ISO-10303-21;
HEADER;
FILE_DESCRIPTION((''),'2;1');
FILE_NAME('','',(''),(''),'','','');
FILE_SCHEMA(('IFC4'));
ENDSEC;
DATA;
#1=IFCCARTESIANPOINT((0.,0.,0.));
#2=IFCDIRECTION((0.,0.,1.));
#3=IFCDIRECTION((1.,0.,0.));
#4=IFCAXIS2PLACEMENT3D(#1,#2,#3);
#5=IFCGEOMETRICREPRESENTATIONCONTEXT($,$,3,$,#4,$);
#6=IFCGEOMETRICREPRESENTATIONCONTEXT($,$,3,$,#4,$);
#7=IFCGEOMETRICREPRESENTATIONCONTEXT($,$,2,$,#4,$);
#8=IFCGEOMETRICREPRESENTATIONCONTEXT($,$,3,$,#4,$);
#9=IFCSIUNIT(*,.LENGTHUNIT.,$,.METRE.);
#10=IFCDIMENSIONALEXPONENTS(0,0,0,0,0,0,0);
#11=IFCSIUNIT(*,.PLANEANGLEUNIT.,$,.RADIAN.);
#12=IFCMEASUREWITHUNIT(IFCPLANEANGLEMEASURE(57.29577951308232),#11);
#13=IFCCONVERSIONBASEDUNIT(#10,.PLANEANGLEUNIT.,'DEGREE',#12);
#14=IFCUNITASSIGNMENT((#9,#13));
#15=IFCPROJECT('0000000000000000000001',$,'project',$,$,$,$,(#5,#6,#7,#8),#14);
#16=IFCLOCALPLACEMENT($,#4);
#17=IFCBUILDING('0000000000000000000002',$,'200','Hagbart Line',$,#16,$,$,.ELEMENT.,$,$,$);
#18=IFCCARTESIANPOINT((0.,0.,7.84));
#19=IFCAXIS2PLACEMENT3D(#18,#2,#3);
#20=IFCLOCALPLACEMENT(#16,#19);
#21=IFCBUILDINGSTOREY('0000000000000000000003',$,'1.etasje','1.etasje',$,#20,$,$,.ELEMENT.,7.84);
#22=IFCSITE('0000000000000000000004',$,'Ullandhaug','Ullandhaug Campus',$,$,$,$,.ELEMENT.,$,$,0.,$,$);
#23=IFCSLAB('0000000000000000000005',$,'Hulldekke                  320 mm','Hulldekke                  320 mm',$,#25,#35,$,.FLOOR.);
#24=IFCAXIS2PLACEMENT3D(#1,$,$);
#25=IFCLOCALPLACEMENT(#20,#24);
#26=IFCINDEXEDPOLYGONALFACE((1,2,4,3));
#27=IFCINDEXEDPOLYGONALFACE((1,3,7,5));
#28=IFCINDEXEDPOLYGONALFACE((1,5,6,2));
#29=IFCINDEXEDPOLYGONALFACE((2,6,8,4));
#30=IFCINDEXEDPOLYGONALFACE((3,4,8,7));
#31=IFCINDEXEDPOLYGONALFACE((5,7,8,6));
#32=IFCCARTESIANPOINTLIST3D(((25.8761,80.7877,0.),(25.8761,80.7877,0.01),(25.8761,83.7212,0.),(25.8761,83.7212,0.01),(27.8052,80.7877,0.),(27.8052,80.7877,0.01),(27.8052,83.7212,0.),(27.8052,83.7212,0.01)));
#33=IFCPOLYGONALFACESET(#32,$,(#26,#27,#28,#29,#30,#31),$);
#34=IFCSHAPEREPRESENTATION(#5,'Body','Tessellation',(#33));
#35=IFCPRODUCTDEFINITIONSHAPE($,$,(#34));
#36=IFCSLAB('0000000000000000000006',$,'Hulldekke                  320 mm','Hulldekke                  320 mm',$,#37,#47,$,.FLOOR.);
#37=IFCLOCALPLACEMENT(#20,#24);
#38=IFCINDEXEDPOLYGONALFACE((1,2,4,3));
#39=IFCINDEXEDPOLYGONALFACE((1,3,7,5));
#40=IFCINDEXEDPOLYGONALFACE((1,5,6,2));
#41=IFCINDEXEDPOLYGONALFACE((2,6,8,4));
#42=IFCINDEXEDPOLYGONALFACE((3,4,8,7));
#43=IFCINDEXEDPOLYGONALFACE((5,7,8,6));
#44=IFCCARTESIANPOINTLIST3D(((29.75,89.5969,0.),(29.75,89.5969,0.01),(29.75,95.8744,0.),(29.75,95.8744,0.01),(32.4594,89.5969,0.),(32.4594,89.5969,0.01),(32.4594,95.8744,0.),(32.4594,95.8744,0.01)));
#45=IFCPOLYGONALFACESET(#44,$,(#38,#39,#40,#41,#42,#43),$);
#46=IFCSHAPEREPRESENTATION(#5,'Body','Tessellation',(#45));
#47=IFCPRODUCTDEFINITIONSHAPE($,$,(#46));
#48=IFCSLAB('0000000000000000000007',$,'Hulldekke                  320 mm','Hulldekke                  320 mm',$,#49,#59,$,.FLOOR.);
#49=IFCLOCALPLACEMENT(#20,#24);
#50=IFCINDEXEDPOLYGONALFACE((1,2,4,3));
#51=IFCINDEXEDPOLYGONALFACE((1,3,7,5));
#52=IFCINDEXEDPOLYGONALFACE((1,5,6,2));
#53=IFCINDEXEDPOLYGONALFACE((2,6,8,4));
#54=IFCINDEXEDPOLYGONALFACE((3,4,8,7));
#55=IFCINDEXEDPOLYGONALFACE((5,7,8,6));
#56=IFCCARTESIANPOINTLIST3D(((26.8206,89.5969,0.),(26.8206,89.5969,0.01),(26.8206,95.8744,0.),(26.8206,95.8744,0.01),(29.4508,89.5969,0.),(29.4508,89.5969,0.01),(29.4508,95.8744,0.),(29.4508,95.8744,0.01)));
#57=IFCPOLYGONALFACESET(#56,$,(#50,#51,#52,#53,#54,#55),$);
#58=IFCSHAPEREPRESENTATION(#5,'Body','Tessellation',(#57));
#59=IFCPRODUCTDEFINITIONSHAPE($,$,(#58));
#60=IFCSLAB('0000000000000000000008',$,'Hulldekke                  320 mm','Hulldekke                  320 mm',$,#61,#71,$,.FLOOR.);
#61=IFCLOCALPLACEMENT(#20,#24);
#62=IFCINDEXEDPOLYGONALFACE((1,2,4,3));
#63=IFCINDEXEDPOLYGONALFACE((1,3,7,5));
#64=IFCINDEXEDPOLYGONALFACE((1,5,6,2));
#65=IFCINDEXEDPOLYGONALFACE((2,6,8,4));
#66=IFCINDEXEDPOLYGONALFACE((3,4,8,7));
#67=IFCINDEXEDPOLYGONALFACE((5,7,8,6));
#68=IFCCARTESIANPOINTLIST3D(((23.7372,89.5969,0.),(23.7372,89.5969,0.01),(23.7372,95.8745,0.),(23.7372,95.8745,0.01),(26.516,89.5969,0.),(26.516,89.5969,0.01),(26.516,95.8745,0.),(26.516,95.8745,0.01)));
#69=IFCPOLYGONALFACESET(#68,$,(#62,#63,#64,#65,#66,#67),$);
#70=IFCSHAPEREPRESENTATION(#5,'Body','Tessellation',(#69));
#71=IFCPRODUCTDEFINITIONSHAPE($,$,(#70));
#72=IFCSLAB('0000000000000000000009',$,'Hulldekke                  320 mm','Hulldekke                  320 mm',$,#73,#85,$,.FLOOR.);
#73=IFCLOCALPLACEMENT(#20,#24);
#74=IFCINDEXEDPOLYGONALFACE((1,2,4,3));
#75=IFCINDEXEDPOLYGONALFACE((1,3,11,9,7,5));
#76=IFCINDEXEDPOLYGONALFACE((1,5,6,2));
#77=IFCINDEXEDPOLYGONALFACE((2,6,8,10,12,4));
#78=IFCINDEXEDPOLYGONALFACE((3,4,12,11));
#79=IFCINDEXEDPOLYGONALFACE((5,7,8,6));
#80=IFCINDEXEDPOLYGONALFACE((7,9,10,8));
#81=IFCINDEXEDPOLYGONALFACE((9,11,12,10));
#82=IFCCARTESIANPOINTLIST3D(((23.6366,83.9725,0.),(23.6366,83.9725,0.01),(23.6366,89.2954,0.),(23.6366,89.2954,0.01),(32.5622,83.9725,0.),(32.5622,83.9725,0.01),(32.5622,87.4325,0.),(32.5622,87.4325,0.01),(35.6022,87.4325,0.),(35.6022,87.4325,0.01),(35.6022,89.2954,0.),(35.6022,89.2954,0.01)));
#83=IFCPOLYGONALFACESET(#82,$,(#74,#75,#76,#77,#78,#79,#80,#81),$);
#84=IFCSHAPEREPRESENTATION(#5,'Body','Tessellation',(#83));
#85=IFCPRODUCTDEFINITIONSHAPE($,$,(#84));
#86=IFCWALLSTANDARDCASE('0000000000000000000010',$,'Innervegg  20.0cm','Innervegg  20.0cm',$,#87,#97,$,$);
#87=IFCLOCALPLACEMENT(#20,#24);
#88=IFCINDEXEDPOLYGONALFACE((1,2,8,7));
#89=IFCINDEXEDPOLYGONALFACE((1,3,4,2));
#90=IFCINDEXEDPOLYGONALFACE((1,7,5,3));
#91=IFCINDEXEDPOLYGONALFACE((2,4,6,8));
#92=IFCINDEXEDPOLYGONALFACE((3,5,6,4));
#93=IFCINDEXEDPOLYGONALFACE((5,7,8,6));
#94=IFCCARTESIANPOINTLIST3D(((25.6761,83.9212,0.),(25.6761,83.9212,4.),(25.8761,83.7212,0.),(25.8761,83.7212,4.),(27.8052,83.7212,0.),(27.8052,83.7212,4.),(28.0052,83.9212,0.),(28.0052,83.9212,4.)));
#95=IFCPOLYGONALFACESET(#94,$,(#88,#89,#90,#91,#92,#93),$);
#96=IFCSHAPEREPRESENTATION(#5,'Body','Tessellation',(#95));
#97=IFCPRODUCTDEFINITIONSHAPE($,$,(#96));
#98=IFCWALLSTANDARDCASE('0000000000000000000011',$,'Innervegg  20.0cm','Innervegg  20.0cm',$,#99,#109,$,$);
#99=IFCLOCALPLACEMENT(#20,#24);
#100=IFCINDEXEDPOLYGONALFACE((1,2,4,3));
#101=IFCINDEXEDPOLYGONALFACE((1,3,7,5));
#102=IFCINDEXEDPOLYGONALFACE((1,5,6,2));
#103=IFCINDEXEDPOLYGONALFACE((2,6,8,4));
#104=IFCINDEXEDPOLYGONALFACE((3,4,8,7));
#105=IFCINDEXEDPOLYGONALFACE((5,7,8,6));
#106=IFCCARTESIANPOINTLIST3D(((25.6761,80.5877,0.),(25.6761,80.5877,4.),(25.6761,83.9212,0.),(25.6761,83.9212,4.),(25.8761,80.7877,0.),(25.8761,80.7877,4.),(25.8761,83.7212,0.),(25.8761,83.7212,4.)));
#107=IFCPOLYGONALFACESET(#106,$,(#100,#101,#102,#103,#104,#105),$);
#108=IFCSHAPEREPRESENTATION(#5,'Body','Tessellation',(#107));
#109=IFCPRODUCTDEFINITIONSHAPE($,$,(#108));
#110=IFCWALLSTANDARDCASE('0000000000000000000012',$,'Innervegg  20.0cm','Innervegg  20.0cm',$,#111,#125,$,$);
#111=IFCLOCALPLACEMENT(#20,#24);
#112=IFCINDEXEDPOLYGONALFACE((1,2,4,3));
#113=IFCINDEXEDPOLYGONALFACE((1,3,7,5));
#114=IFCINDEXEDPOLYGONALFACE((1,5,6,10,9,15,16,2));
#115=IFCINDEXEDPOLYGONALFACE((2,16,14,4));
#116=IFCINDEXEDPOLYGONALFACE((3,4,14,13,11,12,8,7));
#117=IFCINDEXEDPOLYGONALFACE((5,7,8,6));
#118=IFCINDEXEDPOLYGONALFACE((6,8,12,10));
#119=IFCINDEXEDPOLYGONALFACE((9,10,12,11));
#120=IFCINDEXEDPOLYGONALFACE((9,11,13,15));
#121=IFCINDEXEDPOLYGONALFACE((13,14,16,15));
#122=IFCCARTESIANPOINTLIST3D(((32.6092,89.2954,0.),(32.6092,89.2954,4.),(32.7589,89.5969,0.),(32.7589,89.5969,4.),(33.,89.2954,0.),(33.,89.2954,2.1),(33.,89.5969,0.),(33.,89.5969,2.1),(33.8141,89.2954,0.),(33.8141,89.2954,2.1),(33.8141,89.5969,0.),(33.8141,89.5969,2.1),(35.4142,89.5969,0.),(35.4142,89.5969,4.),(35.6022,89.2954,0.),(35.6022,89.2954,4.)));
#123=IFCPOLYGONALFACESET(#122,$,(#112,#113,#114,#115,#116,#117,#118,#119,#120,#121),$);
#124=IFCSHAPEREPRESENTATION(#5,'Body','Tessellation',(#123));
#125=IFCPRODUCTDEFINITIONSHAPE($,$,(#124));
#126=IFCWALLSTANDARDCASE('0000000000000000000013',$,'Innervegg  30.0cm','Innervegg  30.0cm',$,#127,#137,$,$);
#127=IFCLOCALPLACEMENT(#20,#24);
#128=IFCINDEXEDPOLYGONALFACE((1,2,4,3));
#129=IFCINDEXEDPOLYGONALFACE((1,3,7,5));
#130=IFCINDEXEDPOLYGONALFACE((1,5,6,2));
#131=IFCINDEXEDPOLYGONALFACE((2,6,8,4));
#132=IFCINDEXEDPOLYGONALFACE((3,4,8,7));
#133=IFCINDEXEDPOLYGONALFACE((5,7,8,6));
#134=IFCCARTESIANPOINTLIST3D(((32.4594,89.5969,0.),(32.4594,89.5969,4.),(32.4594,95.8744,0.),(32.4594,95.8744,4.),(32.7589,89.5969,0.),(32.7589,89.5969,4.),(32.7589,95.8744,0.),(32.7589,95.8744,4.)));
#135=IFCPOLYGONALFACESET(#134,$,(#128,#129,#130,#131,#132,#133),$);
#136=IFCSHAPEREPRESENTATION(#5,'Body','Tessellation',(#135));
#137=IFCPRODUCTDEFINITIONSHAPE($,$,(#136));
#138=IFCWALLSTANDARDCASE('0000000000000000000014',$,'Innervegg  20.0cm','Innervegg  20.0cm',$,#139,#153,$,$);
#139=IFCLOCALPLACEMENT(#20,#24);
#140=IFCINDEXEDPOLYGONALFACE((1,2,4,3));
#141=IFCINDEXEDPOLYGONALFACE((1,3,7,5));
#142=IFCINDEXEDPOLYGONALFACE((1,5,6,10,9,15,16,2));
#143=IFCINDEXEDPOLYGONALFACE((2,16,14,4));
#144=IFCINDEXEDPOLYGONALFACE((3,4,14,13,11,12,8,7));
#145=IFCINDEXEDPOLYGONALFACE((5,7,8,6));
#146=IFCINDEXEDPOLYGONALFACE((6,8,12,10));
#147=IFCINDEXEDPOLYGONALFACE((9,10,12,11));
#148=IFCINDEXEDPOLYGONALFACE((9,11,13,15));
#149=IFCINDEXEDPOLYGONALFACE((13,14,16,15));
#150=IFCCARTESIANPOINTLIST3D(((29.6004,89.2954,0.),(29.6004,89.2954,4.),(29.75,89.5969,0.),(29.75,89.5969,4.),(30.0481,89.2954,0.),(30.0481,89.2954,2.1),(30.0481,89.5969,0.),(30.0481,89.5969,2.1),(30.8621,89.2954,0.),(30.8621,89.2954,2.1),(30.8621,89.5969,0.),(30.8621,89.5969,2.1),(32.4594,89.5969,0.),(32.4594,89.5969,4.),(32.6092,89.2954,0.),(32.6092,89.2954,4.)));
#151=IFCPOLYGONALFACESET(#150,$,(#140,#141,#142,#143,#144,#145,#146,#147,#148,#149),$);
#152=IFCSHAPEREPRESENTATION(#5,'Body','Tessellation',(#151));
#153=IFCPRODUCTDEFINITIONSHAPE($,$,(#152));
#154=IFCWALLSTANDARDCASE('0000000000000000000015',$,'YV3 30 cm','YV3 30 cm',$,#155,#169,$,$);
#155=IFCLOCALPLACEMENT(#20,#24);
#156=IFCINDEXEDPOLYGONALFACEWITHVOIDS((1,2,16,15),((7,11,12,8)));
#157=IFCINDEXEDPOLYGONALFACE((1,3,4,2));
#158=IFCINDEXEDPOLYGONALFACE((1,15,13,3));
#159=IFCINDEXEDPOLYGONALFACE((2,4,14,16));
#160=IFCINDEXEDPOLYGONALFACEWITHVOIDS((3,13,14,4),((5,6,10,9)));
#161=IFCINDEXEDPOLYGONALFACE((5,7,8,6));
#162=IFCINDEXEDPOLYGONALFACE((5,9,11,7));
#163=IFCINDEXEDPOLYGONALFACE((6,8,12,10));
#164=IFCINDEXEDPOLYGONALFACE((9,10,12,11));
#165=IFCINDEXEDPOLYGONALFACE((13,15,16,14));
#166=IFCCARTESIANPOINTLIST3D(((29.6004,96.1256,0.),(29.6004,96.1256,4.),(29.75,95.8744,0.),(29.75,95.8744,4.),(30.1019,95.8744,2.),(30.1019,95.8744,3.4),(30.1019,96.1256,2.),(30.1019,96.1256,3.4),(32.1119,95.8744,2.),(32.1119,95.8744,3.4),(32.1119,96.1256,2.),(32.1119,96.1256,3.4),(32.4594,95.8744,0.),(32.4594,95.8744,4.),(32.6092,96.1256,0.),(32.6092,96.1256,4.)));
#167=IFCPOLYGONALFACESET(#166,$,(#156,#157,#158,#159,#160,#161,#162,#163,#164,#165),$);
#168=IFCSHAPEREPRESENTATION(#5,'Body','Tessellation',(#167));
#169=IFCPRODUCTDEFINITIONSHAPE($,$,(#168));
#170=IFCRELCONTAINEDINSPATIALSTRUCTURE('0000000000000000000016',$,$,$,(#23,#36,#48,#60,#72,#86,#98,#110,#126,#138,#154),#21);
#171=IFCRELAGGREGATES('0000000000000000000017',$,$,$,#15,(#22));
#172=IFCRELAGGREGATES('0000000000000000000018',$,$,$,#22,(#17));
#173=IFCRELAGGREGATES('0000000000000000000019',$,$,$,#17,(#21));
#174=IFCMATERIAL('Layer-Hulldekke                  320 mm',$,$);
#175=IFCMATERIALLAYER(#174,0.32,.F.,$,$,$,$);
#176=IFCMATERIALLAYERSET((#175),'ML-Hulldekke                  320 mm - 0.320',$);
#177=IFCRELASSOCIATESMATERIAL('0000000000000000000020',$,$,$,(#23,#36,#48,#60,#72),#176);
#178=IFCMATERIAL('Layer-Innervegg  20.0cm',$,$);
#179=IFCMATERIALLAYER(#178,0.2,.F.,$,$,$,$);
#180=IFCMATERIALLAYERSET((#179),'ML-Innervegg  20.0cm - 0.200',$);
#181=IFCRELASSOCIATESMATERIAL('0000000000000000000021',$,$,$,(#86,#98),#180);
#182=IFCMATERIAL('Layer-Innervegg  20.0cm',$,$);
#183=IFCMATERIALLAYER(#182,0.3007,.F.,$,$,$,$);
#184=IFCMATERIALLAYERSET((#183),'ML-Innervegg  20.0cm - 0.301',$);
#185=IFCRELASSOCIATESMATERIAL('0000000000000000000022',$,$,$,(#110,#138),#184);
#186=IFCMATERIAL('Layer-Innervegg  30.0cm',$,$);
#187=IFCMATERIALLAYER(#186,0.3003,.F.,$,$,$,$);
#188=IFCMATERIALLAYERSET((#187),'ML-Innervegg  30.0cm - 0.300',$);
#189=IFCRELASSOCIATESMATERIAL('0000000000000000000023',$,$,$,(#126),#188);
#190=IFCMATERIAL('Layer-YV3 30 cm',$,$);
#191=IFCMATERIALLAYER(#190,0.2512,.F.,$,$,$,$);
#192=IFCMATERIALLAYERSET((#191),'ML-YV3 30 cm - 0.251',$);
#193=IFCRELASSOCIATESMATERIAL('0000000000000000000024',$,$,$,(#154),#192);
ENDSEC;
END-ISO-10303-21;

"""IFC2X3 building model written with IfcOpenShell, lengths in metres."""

from ifc_helpers import new_model, entity, si_unit, converted_unit, frame, origin_with_axes, place, context, project, spatial, polyline, outline, extrude, material, layer, layer_set, layer_usage, element, save


model = new_model("IFC2X3")

# Units and contexts
context_of_model_1 = context(None, 3, world=origin_with_axes())
context_of_model_2 = context(None, 3, world=origin_with_axes())
context_of_model_3 = context(None, 2, world=origin_with_axes())
context_of_model_4 = context(None, 3, world=origin_with_axes())
ifc_project = project(units=[si_unit("LENGTHUNIT", "METRE"), converted_unit("PLANEANGLEUNIT", "DEGREE", entity("IfcPlaneAngleMeasure", 57.29577951308232), si_unit("PLANEANGLEUNIT", "RADIAN"), dimensions=[0, 0, 0, 0, 0, 0, 0])], contexts=[context_of_model_1, context_of_model_2, context_of_model_3, context_of_model_4])

# Site, building, storey
site = spatial("IfcSite", under=ifc_project, Name="Ullandhaug", Description="Ullandhaug Campus", CompositionType="ELEMENT", RefElevation=0.0)
building_placement = place(None, origin_with_axes())
building = spatial("IfcBuilding", under=site, at=building_placement, Name="200", Description="Hagbart Line", CompositionType="ELEMENT")
storey_placement = place(building_placement, frame((0.0, 0.0, 7.84), z_axis=(0.0, 0.0, 1.0), x_axis=(1.0, 0.0, 0.0)))
storey = spatial("IfcBuildingStorey", under=building, at=storey_placement, Name="1.etasje", Description="1.etasje", CompositionType="ELEMENT", Elevation=7.84)

# Slabs
ifc_material_1 = material(Name="Layer-Hulldekke                  320 mm")
ifc_layer_1 = layer(ifc_material_1, 0.32, ventilated=False)
ifc_layer_set_1 = layer_set([ifc_layer_1], Name="ML-Hulldekke                  320 mm - 0.320")
ifc_layer_usage_1 = layer_usage(ifc_layer_set_1, "AXIS2", "POSITIVE", 0.0)
slab_1_placement = place(storey_placement, frame((25.8761, 80.7877, 0.0), z_axis=(0.0, 0.0, 1.0), x_axis=(1.0, 0.0, 0.0)))
element("IfcSlab", 1, at=slab_1_placement, inside=storey, material=ifc_layer_usage_1, Name="Hulldekke                  320 mm", Description="Hulldekke                  320 mm", PredefinedType="FLOOR", context=context_of_model_1, shape_type="SweptSolid", body=[
    extrude(outline(polyline([(0.0, 0.0), (1.929, 0.0), (1.929, 2.9335), (0.0, 2.9335), (0.0, 0.0)])), origin_with_axes(), (0.0, 0.0, 1.0), 0.01),
])
slab_2_placement = place(storey_placement, frame((29.75, 89.5969, 0.0), z_axis=(0.0, 0.0, 1.0), x_axis=(1.0, 0.0, 0.0)))
element("IfcSlab", 2, at=slab_2_placement, inside=storey, material=ifc_layer_usage_1, Name="Hulldekke                  320 mm", Description="Hulldekke                  320 mm", PredefinedType="FLOOR", context=context_of_model_1, shape_type="SweptSolid", body=[
    extrude(outline(polyline([(0.0, 0.0), (2.7094, 0.0), (2.7094, 6.2775), (0.0, 6.2775), (0.0, 0.0)])), origin_with_axes(), (0.0, 0.0, 1.0), 0.01),
])
slab_3_placement = place(storey_placement, frame((26.8206, 89.5969, 0.0), z_axis=(0.0, 0.0, 1.0), x_axis=(1.0, 0.0, 0.0)))
element("IfcSlab", 3, at=slab_3_placement, inside=storey, material=ifc_layer_usage_1, Name="Hulldekke                  320 mm", Description="Hulldekke                  320 mm", PredefinedType="FLOOR", context=context_of_model_1, shape_type="SweptSolid", body=[
    extrude(outline(polyline([(0.0, 0.0), (2.6303, 0.0), (2.6303, 6.2775), (0.0, 6.2775), (0.0, 0.0)])), origin_with_axes(), (0.0, 0.0, 1.0), 0.01),
])
slab_4_placement = place(storey_placement, frame((23.7372, 89.5969, 0.0), z_axis=(0.0, 0.0, 1.0), x_axis=(1.0, 0.0, 0.0)))
element("IfcSlab", 4, at=slab_4_placement, inside=storey, material=ifc_layer_usage_1, Name="Hulldekke                  320 mm", Description="Hulldekke                  320 mm", PredefinedType="FLOOR", context=context_of_model_1, shape_type="SweptSolid", body=[
    extrude(outline(polyline([(0.0, 0.0), (2.7788, 0.0), (2.7788, 6.2775), (0.0, 6.2775), (0.0, 0.0)])), origin_with_axes(), (0.0, 0.0, 1.0), 0.01),
])
slab_5_placement = place(storey_placement, frame((23.6366, 83.9725, 0.0), z_axis=(0.0, 0.0, 1.0), x_axis=(1.0, 0.0, 0.0)))
element("IfcSlab", 5, at=slab_5_placement, inside=storey, material=ifc_layer_usage_1, Name="Hulldekke                  320 mm", Description="Hulldekke                  320 mm", PredefinedType="FLOOR", context=context_of_model_1, shape_type="SweptSolid", body=[
    extrude(outline(polyline([(0.0, 0.0), (8.9255, 0.0), (8.9255, 3.46), (11.9655, 3.46), (11.9655, 5.323), (0.0, 5.323), (0.0, 0.0)])), origin_with_axes(), (0.0, 0.0, 1.0), 0.01),
])

# Walls
ifc_material_2 = material(Name="Layer-Innervegg  20.0cm")
ifc_layer_2 = layer(ifc_material_2, 0.2, ventilated=False)
ifc_layer_set_2 = layer_set([ifc_layer_2], Name="ML-Innervegg  20.0cm - 0.200")
ifc_layer_usage_2 = layer_usage(ifc_layer_set_2, "AXIS2", "POSITIVE", 0.0)
wall_1_placement = place(storey_placement, frame((28.0052, 83.9212, 0.0), z_axis=(0.0, 0.0, 1.0), x_axis=(-1.0, 0.0, 0.0)))
element("IfcWallStandardCase", 6, at=wall_1_placement, inside=storey, material=ifc_layer_usage_2, Name="Innervegg  20.0cm", Description="Innervegg  20.0cm", context=context_of_model_1, shape_type="SweptSolid", body=[
    extrude(outline(polyline([(0.0, 0.0), (2.329, 0.0), (2.129, 0.2), (0.2, 0.2), (0.0, 0.0)])), frame((0.0, 0.0, 0.0), z_axis=(0.0, 0.0, 1.0), x_axis=(1.0, 0.0, 0.0)), (0.0, 0.0, 1.0), 4.0),
])
wall_2_placement = place(storey_placement, frame((25.6761, 83.9212, 0.0), z_axis=(0.0, 0.0, 1.0), x_axis=(0.0, -1.0, 0.0)))
element("IfcWallStandardCase", 7, at=wall_2_placement, inside=storey, material=ifc_layer_usage_2, Name="Innervegg  20.0cm", Description="Innervegg  20.0cm", context=context_of_model_1, shape_type="SweptSolid", body=[
    extrude(outline(polyline([(0.0, 0.0), (3.3335, 0.0), (3.1335, 0.2), (0.2, 0.2), (0.0, 0.0)])), frame((0.0, 0.0, 0.0), z_axis=(0.0, 0.0, 1.0), x_axis=(1.0, 0.0, 0.0)), (0.0, 0.0, 1.0), 4.0),
])

# Wall, opening
ifc_material_3 = material(Name="Layer-Innervegg  20.0cm")
ifc_layer_3 = layer(ifc_material_3, 0.3007, ventilated=False)
ifc_layer_set_3 = layer_set([ifc_layer_3], Name="ML-Innervegg  20.0cm - 0.301")
ifc_layer_usage_3 = layer_usage(ifc_layer_set_3, "AXIS2", "POSITIVE", 0.0)
wall_3_placement = place(storey_placement, frame((32.6092, 89.2954, 0.0), z_axis=(0.0, 0.0, 1.0), x_axis=(1.0, 0.0, 0.0)))
wall_3 = element("IfcWallStandardCase", 8, at=wall_3_placement, inside=storey, material=ifc_layer_usage_3, Name="Innervegg  20.0cm", Description="Innervegg  20.0cm", context=context_of_model_1, shape_type="SweptSolid", body=[
    extrude(outline(polyline([(0.0, 0.0), (2.993, 0.0), (2.805, 0.3015), (0.1498, 0.3015), (0.0, 0.0)])), origin_with_axes(), (0.0, 0.0, 1.0), 4.0),
])
opening_1_placement = place(wall_3_placement, frame((0.3909, 0.3015, 0.0), z_axis=(0.0, 0.0, 1.0), x_axis=(1.0, 0.0, 0.0)))
element("IfcOpeningElement", 9, at=opening_1_placement, cuts=wall_3, context=context_of_model_1, shape_type="SweptSolid", body=[
    extrude(outline(polyline([(0.0, 0.0), (2.1, 0.0), (2.1, 0.8141), (0.0, 0.8141), (0.0, 0.0)])), frame((0.0, 0.0, 0.0), z_axis=(0.0, 1.0, 0.0), x_axis=(0.0, 0.0, 1.0)), (0.0, 0.0, -1.0), 0.3015),
])

# Wall
ifc_material_4 = material(Name="Layer-Innervegg  30.0cm")
ifc_layer_4 = layer(ifc_material_4, 0.3003, ventilated=False)
ifc_layer_set_4 = layer_set([ifc_layer_4], Name="ML-Innervegg  30.0cm - 0.300")
ifc_layer_usage_4 = layer_usage(ifc_layer_set_4, "AXIS2", "POSITIVE", 0.0)
wall_4_placement = place(storey_placement, frame((32.4594, 95.8744, 0.0), z_axis=(0.0, 0.0, 1.0), x_axis=(0.0, -1.0, 0.0)))
element("IfcWallStandardCase", 10, at=wall_4_placement, inside=storey, material=ifc_layer_usage_4, Name="Innervegg  30.0cm", Description="Innervegg  30.0cm", context=context_of_model_1, shape_type="SweptSolid", body=[
    extrude(outline(polyline([(0.0, 0.0), (6.2775, 0.0), (6.2775, 0.2995), (0.0, 0.2995), (0.0, 0.0)])), frame((0.0, 0.0, 0.0), z_axis=(0.0, 0.0, 1.0), x_axis=(1.0, 0.0, 0.0)), (0.0, 0.0, 1.0), 4.0),
])

# Walls, openings
wall_5_placement = place(storey_placement, frame((29.6004, 89.2954, 0.0), z_axis=(0.0, 0.0, 1.0), x_axis=(1.0, 0.0, 0.0)))
wall_5 = element("IfcWallStandardCase", 11, at=wall_5_placement, inside=storey, material=ifc_layer_usage_3, Name="Innervegg  20.0cm", Description="Innervegg  20.0cm", context=context_of_model_1, shape_type="SweptSolid", body=[
    extrude(outline(polyline([(0.0, 0.0), (3.0088, 0.0), (2.859, 0.3015), (0.1496, 0.3015), (0.0, 0.0)])), origin_with_axes(), (0.0, 0.0, 1.0), 4.0),
])
opening_2_placement = place(wall_5_placement, frame((0.4477, 0.3015, 0.0), z_axis=(0.0, 0.0, 1.0), x_axis=(1.0, 0.0, 0.0)))
element("IfcOpeningElement", 12, at=opening_2_placement, cuts=wall_5, context=context_of_model_1, shape_type="SweptSolid", body=[
    extrude(outline(polyline([(0.0, 0.0), (2.1, 0.0), (2.1, 0.8141), (0.0, 0.8141), (0.0, 0.0)])), frame((0.0, 0.0, 0.0), z_axis=(0.0, 1.0, 0.0), x_axis=(0.0, 0.0, 1.0)), (0.0, 0.0, -1.0), 0.3015),
])
ifc_material_5 = material(Name="Layer-YV3 30 cm")
ifc_layer_5 = layer(ifc_material_5, 0.2512, ventilated=False)
ifc_layer_set_5 = layer_set([ifc_layer_5], Name="ML-YV3 30 cm - 0.251")
ifc_layer_usage_5 = layer_usage(ifc_layer_set_5, "AXIS2", "POSITIVE", 0.0)
wall_6_placement = place(storey_placement, frame((32.6092, 96.1256, 0.0), z_axis=(0.0, 0.0, 1.0), x_axis=(-1.0, 0.0, 0.0)))
wall_6 = element("IfcWallStandardCase", 13, at=wall_6_placement, inside=storey, material=ifc_layer_usage_5, Name="YV3 30 cm", Description="YV3 30 cm", context=context_of_model_1, shape_type="SweptSolid", body=[
    extrude(outline(polyline([(0.0, 0.0), (3.0088, 0.0), (2.8592, 0.2512), (0.1498, 0.2512), (0.0, 0.0)])), frame((0.0, 0.0, 0.0), z_axis=(0.0, 0.0, 1.0), x_axis=(1.0, 0.0, 0.0)), (0.0, 0.0, 1.0), 4.0),
])
opening_3_placement = place(wall_6_placement, frame((0.4973, 0.2512, 2.0), z_axis=(0.0, 0.0, 1.0), x_axis=(1.0, 0.0, 0.0)))
element("IfcOpeningElement", 14, at=opening_3_placement, cuts=wall_6, context=context_of_model_1, shape_type="SweptSolid", body=[
    extrude(outline(polyline([(0.0, 0.0), (1.4, 0.0), (1.4, 2.01), (0.0, 2.01), (0.0, 0.0)])), frame((0.0, 0.0, 0.0), z_axis=(0.0, 1.0, 0.0), x_axis=(0.0, 0.0, 1.0)), (0.0, 0.0, -1.0), 0.2512),
])

save(model, "model.ifc")
